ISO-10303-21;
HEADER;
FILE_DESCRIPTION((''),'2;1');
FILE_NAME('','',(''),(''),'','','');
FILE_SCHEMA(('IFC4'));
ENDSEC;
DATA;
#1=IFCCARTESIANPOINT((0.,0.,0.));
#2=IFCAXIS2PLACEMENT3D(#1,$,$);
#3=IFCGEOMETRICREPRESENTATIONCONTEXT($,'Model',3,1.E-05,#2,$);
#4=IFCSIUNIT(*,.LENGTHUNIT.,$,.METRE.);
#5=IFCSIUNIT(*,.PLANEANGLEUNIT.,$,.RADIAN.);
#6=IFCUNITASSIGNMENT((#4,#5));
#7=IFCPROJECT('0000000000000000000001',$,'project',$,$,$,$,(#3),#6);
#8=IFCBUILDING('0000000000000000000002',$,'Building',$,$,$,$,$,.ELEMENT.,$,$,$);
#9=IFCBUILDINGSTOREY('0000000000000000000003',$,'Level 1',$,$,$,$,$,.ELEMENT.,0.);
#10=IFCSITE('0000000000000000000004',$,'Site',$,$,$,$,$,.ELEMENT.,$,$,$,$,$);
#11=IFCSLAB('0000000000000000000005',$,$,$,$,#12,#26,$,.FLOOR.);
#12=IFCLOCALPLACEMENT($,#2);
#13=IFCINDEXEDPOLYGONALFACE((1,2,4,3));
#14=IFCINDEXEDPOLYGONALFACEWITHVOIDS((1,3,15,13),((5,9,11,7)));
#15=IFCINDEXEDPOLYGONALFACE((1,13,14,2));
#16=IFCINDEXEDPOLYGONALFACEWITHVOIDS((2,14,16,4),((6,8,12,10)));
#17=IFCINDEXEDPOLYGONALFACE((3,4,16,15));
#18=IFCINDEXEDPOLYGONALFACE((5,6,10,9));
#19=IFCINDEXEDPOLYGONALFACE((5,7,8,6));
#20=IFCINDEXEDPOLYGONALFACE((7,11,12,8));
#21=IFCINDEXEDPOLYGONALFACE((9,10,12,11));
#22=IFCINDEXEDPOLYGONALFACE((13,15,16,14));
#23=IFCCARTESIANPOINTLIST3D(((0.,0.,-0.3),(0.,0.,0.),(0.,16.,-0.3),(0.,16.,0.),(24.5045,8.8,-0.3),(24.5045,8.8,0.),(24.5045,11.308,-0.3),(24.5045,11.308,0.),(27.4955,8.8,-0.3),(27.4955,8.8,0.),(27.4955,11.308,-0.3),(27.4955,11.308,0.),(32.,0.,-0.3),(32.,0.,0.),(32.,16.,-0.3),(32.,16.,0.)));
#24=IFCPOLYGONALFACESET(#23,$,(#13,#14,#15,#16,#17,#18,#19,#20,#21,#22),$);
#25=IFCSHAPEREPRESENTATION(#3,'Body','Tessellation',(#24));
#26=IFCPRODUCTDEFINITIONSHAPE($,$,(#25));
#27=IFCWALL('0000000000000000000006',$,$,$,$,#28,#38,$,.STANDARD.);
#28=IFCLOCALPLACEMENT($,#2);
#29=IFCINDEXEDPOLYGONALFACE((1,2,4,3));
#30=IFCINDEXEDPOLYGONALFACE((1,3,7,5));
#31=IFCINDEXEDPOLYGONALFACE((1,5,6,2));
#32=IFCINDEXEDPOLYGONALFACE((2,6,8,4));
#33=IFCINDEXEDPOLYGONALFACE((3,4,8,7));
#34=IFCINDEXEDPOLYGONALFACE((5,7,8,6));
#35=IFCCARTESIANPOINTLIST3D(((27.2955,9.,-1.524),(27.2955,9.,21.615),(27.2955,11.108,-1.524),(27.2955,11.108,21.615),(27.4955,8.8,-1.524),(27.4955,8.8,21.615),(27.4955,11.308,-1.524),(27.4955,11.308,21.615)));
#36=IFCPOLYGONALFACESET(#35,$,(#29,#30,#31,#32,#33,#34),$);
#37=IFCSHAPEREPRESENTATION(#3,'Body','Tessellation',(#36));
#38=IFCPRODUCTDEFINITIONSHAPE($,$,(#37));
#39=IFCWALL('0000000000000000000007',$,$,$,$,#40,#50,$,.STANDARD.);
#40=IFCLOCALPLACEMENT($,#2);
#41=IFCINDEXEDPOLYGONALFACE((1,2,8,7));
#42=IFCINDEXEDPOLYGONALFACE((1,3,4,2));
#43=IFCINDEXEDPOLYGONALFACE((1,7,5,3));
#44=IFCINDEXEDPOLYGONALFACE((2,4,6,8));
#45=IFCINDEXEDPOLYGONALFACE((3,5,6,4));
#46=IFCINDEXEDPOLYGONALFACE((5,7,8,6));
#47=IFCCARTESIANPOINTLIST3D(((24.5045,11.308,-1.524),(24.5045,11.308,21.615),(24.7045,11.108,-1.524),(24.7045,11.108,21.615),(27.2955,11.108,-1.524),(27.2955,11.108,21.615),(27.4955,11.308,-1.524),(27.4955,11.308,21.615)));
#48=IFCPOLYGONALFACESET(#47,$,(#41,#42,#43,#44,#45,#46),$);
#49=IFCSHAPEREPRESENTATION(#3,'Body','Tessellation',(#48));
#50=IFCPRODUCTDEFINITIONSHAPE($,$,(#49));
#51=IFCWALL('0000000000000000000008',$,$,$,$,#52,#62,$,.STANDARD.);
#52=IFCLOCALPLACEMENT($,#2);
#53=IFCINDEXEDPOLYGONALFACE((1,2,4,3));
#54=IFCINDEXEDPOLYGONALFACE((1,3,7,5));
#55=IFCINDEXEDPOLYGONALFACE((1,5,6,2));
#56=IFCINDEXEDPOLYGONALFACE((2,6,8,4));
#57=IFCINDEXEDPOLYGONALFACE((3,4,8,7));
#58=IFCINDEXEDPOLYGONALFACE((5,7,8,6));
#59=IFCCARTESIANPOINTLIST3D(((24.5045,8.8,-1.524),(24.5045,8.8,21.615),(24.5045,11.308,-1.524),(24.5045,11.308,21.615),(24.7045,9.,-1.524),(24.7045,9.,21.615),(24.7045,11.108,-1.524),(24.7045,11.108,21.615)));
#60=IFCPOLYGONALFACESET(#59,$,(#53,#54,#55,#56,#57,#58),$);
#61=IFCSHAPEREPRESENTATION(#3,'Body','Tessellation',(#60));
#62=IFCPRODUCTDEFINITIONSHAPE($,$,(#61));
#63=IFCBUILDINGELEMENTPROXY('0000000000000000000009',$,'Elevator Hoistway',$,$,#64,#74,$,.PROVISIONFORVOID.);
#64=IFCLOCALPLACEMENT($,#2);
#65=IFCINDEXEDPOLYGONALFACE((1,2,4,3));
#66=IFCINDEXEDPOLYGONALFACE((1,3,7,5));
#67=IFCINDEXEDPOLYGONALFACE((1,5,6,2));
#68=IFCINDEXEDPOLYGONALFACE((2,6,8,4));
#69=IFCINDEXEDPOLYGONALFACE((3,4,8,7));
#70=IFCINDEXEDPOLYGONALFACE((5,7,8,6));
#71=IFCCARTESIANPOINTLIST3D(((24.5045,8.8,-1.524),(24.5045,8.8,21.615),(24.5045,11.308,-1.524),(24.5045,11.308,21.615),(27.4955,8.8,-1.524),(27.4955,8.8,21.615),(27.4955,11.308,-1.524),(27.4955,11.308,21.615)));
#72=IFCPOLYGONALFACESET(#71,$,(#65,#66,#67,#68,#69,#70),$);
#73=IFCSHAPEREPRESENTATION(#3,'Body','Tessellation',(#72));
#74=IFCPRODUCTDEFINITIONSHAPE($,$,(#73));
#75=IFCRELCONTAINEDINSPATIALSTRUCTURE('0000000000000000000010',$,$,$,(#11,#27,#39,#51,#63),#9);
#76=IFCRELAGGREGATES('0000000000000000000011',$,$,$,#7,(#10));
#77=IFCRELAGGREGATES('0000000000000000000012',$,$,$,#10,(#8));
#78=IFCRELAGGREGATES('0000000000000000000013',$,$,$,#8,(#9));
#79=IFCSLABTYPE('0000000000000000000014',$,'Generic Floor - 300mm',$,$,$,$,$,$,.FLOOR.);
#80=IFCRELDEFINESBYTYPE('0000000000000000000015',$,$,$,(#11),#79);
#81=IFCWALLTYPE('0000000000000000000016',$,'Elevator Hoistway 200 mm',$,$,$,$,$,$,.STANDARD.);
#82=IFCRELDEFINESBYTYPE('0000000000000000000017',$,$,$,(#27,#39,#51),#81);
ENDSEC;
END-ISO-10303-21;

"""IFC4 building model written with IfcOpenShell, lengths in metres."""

from ifc_helpers import new_model, si_unit, frame, origin, place, context, project, spatial, polyline, outline, extrude, type_object, element, save


model = new_model("IFC4")

# Units and contexts
model_context = context("Model", 3, precision=1e-05, world=origin())
ifc_project = project(units=[si_unit("LENGTHUNIT", "METRE"), si_unit("PLANEANGLEUNIT", "RADIAN")], contexts=[model_context])

# Site, building, storey
site = spatial("IfcSite", under=ifc_project, Name="Site", CompositionType="ELEMENT")
building = spatial("IfcBuilding", under=site, Name="Building", CompositionType="ELEMENT")
storey = spatial("IfcBuildingStorey", under=building, Name="Level 1", CompositionType="ELEMENT", Elevation=0.0)

# Slab, opening
slab_type = type_object("IfcSlabType", Name="Generic Floor - 300mm", PredefinedType="FLOOR")
slab_placement = place(None, origin())
slab = element("IfcSlab", 1, at=slab_placement, inside=storey, type_object=slab_type, PredefinedType="FLOOR", context=model_context, shape_type="SweptSolid", body=[
    extrude(outline(polyline([(0.0, 0.0), (32.0, 0.0), (32.0, 16.0), (0.0, 16.0), (0.0, 0.0)])), origin(), (0.0, 0.0, -1.0), 0.3),
])
opening_1_placement = place(None, frame((0.0, 0.0, 0.001)))
element("IfcOpeningElement", 2, at=opening_1_placement, cuts=slab, PredefinedType="OPENING", context=model_context, shape_type="SweptSolid", body=[
    extrude(outline(polyline([(24.5045, 8.8), (27.4955, 8.8), (27.4955, 11.308), (24.5045, 11.308), (24.5045, 8.8)])), origin(), (0.0, 0.0, -1.0), 0.302),
])

# Shared definitions
wall_type = type_object("IfcWallType", Name="Elevator Hoistway 200 mm", PredefinedType="STANDARD")

# Walls
wall_1_placement = place(None, frame((27.3955, 8.9, -1.524), z_axis=(0.0, 0.0, 1.0), x_axis=(0.0, 1.0, 0.0)))
element("IfcWall", 3, at=wall_1_placement, inside=storey, type_object=wall_type, PredefinedType="STANDARD", context=model_context, shape_type="SweptSolid", body=[
    extrude(outline(polyline([(-0.1, -0.1), (2.408, -0.1), (2.208, 0.1), (0.1, 0.1), (-0.1, -0.1)])), origin(), (0.0, 0.0, 1.0), 23.139),
])
wall_2_placement = place(None, frame((27.3955, 11.208, -1.524), z_axis=(0.0, 0.0, 1.0), x_axis=(-1.0, 0.0, 0.0)))
element("IfcWall", 4, at=wall_2_placement, inside=storey, type_object=wall_type, PredefinedType="STANDARD", context=model_context, shape_type="SweptSolid", body=[
    extrude(outline(polyline([(-0.1, -0.1), (2.891, -0.1), (2.691, 0.1), (0.1, 0.1), (-0.1, -0.1)])), origin(), (0.0, 0.0, 1.0), 23.139),
])
wall_3_placement = place(None, frame((24.6045, 11.208, -1.524), z_axis=(0.0, 0.0, 1.0), x_axis=(0.0, -1.0, 0.0)))
element("IfcWall", 5, at=wall_3_placement, inside=storey, type_object=wall_type, PredefinedType="STANDARD", context=model_context, shape_type="SweptSolid", body=[
    extrude(outline(polyline([(-0.1, -0.1), (2.408, -0.1), (2.208, 0.1), (0.1, 0.1), (-0.1, -0.1)])), origin(), (0.0, 0.0, 1.0), 23.139),
])

# Building element proxy
proxy_placement = place(None, frame((0.0, 0.0, 21.615)))
element("IfcBuildingElementProxy", 6, at=proxy_placement, inside=storey, Name="Elevator Hoistway", PredefinedType="PROVISIONFORVOID", context=model_context, shape_type="SweptSolid", body=[
    extrude(outline(polyline([(24.5045, 8.8), (27.4955, 8.8), (27.4955, 11.308), (24.5045, 11.308), (24.5045, 8.8)])), origin(), (0.0, 0.0, -1.0), 23.139),
])

save(model, "model.ifc")
